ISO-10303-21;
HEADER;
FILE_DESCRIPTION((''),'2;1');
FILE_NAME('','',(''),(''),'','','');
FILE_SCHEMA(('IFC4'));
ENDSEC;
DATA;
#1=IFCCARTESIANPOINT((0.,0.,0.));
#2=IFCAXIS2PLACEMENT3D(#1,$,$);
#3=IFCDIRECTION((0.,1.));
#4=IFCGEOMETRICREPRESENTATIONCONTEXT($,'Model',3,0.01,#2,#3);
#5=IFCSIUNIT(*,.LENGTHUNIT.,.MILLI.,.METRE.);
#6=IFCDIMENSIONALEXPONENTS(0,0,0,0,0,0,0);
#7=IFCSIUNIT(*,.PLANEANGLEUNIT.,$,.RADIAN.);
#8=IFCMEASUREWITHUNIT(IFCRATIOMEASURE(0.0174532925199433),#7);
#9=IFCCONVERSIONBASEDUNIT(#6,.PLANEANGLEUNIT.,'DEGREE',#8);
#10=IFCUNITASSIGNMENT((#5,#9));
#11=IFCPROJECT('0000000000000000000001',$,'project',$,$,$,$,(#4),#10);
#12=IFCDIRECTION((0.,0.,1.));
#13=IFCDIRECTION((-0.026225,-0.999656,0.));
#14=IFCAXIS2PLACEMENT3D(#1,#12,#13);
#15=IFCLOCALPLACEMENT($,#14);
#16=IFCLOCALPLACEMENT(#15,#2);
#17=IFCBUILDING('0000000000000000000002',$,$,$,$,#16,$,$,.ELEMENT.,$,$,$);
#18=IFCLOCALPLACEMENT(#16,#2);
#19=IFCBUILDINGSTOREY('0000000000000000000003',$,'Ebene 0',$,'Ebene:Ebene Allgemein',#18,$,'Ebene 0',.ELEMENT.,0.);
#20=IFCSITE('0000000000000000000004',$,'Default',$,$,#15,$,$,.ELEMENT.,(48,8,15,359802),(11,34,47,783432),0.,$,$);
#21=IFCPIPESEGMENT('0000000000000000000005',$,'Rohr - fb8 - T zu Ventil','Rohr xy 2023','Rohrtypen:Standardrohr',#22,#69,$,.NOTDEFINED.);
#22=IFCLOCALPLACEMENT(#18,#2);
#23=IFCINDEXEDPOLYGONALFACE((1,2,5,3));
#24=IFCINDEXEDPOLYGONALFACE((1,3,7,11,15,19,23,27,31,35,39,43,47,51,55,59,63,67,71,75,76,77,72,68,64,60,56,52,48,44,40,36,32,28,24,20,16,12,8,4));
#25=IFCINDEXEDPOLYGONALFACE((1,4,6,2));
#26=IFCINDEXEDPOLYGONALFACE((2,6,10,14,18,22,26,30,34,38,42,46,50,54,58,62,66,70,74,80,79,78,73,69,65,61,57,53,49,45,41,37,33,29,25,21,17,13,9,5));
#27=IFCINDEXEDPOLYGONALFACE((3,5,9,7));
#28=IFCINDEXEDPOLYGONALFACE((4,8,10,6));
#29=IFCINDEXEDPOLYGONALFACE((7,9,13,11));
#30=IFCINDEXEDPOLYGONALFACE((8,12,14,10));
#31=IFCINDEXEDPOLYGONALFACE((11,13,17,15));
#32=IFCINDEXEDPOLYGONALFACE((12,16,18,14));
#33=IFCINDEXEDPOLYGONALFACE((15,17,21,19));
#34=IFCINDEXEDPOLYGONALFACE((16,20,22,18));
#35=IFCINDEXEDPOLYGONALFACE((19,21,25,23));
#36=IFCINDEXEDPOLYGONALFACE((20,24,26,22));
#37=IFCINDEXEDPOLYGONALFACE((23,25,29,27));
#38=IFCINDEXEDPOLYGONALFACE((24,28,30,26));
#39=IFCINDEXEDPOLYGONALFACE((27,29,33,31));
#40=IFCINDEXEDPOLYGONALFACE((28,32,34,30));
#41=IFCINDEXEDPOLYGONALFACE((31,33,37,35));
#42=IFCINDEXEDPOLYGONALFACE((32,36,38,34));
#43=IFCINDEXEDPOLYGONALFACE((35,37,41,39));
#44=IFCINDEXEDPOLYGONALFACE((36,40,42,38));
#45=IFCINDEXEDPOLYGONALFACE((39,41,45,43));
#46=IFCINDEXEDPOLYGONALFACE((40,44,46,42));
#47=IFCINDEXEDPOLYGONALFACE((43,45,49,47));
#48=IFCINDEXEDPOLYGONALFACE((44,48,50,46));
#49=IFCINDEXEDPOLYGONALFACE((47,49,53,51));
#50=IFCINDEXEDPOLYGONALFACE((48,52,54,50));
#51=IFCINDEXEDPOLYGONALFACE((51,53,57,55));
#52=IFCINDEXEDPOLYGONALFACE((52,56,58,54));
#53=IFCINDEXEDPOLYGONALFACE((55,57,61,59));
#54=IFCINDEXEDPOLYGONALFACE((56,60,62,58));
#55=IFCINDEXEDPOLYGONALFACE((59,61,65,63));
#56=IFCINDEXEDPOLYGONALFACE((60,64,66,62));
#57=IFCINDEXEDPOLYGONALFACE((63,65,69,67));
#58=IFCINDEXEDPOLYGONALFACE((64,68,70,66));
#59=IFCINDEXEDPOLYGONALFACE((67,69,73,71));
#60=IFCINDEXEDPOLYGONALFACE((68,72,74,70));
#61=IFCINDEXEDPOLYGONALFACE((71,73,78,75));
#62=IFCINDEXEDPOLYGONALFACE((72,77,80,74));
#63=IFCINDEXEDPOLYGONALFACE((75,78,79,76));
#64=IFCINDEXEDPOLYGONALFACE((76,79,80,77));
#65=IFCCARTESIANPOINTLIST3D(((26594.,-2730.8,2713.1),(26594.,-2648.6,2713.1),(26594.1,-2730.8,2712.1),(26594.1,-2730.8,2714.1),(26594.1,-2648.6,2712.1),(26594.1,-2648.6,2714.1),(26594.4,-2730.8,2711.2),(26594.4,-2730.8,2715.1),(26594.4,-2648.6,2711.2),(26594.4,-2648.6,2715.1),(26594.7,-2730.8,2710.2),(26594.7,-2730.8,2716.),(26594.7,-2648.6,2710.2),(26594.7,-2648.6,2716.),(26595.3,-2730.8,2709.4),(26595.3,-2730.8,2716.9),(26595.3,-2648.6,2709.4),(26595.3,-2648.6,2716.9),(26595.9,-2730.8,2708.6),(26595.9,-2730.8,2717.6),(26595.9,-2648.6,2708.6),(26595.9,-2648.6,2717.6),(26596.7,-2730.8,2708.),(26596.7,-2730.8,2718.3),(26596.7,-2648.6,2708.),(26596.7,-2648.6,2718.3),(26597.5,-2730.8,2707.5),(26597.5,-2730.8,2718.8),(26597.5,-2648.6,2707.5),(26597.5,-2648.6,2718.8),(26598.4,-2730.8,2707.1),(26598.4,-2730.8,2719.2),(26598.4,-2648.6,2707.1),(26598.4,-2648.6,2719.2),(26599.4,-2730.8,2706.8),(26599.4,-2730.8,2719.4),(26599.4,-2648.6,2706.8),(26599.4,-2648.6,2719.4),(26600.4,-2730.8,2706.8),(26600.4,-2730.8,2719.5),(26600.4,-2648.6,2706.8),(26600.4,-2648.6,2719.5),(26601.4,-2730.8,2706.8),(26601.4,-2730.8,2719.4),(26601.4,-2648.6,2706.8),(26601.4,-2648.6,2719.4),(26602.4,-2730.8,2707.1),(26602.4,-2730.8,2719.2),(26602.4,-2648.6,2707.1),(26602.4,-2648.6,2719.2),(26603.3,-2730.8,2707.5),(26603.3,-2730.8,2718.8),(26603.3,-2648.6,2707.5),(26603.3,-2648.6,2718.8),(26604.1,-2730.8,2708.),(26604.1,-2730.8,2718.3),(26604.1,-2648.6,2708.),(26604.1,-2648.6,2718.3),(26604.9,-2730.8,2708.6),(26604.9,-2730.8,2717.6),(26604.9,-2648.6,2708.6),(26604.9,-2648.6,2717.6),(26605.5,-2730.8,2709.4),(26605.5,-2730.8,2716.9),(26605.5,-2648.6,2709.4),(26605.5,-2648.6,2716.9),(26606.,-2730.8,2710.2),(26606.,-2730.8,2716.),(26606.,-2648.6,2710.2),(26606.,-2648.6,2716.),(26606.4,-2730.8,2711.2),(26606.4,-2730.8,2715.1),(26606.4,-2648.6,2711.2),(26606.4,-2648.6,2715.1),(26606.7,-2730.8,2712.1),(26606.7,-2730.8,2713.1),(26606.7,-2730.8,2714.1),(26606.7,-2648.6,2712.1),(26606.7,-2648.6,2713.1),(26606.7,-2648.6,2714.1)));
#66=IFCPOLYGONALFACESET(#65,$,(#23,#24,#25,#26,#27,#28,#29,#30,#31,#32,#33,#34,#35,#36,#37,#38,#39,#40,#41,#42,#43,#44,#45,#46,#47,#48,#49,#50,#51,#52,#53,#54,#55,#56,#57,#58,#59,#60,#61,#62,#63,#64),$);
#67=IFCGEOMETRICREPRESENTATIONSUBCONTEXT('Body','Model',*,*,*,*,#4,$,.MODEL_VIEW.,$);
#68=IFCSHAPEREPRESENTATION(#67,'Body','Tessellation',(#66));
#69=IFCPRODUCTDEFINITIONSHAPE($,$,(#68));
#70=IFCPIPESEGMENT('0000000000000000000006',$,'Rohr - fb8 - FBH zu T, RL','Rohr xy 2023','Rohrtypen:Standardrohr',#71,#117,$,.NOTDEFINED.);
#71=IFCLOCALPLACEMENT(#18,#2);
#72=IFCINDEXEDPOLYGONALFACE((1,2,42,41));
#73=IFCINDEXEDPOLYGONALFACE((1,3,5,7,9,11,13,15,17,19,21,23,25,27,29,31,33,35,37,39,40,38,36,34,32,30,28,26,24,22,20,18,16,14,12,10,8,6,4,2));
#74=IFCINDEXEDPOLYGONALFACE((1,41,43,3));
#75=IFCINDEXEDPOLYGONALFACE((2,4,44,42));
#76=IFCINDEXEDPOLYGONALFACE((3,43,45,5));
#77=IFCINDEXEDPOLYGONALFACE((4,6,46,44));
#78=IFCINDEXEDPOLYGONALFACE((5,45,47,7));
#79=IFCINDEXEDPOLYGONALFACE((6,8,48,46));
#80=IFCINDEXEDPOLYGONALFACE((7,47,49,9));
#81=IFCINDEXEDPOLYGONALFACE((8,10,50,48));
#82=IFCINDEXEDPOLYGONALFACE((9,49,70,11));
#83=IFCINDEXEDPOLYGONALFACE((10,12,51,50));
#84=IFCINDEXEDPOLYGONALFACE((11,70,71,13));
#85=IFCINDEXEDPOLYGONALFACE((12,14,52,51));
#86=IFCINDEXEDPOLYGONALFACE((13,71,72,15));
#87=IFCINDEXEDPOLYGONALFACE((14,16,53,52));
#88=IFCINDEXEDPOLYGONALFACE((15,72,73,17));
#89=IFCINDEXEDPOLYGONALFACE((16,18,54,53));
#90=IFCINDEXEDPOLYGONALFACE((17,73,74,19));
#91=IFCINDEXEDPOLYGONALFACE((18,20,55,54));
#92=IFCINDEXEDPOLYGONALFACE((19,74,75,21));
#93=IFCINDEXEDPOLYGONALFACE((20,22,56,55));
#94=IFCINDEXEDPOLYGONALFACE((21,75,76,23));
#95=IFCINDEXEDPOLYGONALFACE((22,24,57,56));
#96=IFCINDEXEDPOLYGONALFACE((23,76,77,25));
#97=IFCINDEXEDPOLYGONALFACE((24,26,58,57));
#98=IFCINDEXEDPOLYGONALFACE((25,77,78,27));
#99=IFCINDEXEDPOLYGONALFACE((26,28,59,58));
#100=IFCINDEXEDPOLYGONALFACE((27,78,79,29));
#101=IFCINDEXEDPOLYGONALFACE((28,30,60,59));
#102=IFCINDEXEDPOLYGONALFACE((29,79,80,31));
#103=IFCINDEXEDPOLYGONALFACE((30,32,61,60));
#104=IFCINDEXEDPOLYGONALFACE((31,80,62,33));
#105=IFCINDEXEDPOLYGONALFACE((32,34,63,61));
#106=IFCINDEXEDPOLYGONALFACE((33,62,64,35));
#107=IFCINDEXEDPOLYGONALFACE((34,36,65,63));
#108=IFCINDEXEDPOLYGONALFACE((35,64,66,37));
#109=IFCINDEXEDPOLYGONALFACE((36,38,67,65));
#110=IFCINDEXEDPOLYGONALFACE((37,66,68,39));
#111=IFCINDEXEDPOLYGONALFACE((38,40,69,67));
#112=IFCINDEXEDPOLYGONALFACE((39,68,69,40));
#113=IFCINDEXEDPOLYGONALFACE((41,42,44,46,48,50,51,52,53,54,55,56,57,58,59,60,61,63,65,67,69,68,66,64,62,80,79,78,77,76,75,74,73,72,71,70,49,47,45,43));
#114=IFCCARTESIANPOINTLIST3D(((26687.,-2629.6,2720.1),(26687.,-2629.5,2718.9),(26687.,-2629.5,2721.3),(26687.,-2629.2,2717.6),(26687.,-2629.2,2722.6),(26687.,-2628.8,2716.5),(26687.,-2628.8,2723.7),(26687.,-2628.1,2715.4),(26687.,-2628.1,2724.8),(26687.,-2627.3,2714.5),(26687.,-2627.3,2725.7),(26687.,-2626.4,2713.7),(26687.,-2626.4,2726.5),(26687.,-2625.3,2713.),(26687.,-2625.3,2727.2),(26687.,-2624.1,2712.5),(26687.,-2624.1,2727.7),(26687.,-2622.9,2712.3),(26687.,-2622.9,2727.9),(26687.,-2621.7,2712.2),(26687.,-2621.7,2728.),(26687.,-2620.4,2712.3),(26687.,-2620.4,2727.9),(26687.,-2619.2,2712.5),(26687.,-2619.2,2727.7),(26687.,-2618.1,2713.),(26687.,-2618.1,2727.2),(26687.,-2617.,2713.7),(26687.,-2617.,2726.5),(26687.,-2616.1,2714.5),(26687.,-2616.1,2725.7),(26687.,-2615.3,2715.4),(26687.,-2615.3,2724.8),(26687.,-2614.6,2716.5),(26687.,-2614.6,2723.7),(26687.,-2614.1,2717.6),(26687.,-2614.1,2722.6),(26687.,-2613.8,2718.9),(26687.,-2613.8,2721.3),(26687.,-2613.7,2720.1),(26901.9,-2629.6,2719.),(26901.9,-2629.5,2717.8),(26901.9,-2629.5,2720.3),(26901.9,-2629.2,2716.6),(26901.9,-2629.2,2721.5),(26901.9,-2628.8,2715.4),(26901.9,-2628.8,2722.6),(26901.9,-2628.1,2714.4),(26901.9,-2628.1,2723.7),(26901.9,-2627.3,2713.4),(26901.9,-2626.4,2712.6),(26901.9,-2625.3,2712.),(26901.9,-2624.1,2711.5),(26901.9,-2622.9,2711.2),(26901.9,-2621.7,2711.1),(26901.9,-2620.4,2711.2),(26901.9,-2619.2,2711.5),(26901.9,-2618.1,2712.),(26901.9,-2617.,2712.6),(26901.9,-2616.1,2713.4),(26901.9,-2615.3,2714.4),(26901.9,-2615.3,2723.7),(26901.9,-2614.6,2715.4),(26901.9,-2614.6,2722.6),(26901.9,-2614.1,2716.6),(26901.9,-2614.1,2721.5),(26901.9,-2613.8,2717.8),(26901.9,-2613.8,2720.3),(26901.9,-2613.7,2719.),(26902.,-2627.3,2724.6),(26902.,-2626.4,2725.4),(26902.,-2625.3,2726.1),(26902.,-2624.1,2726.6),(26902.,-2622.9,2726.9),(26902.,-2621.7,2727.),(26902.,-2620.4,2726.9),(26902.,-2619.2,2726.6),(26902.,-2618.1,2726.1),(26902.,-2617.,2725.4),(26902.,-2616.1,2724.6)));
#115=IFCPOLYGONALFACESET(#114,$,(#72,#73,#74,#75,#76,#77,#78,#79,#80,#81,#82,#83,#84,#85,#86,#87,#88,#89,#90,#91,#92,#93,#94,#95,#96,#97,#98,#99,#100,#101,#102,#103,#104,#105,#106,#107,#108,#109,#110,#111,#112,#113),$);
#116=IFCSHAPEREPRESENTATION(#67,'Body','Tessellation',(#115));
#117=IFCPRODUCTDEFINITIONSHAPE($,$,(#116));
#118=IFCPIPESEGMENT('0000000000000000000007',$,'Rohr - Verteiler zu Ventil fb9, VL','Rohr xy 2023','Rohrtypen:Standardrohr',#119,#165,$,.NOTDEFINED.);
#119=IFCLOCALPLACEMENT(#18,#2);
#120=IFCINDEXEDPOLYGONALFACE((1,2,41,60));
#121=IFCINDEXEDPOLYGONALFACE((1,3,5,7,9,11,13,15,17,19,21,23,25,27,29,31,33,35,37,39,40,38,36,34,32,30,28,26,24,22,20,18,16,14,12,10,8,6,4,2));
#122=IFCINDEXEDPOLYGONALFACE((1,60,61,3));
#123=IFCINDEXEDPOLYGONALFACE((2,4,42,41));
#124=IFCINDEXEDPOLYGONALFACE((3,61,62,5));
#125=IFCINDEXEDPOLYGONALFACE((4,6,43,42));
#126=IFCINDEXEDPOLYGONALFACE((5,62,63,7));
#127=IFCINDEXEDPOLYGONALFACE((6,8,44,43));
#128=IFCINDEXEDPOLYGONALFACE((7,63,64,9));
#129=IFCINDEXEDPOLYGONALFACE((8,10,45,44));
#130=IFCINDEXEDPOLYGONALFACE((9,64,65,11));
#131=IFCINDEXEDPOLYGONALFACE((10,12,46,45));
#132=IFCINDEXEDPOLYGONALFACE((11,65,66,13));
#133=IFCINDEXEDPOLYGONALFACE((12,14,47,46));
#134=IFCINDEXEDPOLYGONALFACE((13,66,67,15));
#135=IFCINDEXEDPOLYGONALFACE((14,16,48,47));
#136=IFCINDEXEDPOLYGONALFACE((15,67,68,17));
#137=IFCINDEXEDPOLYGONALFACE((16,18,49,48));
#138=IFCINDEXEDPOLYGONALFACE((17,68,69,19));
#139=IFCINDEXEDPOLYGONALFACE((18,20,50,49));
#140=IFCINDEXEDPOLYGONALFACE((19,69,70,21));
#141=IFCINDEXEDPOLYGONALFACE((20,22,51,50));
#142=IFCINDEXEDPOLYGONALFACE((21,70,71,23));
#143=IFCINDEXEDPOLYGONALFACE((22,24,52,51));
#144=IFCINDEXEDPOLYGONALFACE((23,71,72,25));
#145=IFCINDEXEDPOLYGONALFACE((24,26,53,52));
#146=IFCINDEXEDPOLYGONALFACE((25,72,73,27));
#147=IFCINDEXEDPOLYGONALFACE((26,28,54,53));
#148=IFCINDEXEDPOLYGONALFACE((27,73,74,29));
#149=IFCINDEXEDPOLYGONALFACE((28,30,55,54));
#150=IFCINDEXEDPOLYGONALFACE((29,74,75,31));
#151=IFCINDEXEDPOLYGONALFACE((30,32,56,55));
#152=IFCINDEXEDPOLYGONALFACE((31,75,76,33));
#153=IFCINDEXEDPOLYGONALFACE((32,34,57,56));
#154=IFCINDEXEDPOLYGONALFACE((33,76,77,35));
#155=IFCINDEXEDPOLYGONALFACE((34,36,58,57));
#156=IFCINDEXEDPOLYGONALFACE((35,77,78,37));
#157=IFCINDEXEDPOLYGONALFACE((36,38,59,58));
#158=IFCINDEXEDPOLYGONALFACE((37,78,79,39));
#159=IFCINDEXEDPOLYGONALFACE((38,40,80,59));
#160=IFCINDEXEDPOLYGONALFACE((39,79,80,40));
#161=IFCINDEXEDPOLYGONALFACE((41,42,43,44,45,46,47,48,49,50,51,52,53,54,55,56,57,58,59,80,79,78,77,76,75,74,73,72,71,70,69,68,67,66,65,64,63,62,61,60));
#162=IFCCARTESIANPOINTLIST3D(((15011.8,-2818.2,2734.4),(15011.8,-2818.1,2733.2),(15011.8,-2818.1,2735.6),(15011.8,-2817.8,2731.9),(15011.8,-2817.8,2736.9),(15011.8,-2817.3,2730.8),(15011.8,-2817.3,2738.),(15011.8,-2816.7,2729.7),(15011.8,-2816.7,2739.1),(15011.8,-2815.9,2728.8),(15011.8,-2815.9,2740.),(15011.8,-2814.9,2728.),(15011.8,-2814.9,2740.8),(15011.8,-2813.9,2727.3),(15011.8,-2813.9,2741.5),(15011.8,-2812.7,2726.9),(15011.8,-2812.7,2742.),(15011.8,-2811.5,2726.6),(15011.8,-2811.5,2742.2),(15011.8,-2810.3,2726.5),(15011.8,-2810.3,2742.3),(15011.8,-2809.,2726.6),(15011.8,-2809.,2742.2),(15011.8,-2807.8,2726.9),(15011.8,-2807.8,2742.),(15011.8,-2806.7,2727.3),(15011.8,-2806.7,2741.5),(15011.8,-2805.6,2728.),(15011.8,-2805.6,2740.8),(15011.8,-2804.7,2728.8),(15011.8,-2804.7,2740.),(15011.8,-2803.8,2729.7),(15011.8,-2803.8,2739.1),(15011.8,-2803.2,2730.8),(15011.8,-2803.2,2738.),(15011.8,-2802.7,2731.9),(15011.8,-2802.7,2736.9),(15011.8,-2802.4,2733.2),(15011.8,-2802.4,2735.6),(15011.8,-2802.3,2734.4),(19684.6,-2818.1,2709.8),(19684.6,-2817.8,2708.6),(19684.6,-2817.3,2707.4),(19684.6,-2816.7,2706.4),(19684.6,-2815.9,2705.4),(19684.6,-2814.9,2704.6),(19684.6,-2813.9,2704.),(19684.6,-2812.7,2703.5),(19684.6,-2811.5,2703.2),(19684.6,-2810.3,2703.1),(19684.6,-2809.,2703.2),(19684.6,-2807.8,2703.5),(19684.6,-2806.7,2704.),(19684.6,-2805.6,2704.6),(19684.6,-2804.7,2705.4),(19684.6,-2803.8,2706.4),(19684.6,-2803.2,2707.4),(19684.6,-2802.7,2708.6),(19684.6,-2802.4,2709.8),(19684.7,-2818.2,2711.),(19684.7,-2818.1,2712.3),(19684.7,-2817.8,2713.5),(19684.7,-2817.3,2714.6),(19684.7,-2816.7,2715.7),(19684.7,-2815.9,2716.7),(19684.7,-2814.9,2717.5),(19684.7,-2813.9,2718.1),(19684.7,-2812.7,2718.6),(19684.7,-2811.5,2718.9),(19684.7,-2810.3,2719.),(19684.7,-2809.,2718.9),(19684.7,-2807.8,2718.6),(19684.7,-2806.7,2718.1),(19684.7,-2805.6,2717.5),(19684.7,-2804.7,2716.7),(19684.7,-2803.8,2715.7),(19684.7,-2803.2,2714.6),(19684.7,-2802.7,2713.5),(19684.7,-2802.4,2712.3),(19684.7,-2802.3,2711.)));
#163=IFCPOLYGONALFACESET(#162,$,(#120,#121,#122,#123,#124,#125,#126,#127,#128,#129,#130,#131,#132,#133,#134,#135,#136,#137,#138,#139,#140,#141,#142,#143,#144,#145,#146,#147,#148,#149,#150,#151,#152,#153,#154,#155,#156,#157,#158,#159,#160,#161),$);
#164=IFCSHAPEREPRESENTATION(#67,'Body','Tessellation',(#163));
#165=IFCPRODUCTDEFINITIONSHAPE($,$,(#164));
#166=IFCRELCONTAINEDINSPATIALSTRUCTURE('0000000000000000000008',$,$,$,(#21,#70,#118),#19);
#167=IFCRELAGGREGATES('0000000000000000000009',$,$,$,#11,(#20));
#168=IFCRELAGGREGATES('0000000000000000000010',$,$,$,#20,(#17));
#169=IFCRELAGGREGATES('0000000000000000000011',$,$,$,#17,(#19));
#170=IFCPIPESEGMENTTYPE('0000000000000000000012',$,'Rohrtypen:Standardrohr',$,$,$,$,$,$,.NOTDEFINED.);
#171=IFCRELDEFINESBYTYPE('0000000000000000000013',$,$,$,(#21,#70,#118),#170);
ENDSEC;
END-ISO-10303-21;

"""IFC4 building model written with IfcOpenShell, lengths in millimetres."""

from ifc_helpers import new_model, entity, si_unit, converted_unit, direction, frame, origin, place, context, subcontext, project, spatial, indexed_curve, outline, extrude, type_object, element, save


model = new_model("IFC4")

# Units and contexts
model_context = context("Model", 3, precision=0.01, world=origin(), true_north=direction((0.0, 1.0)))
body_context = subcontext(model_context, "Body", "Model", "MODEL_VIEW")
ifc_project = project(units=[si_unit("LENGTHUNIT", "METRE", prefix="MILLI"), converted_unit("PLANEANGLEUNIT", "DEGREE", entity("IfcRatioMeasure", 0.0174532925199433), si_unit("PLANEANGLEUNIT", "RADIAN"), dimensions=[0, 0, 0, 0, 0, 0, 0])], contexts=[model_context])

# Site, building, storey
site_placement = place(None, frame((0.0, 0.0, 0.0), z_axis=(0.0, 0.0, 1.0), x_axis=(-0.026225, -0.999656, 0.0)))
site = spatial("IfcSite", under=ifc_project, at=site_placement, Name="Default", CompositionType="ELEMENT", RefLatitude=(48, 8, 15, 359802), RefLongitude=(11, 34, 47, 783432), RefElevation=0.0)
building_placement = place(site_placement, origin())
building = spatial("IfcBuilding", under=site, at=building_placement, CompositionType="ELEMENT")
storey_placement = place(building_placement, origin())
storey = spatial("IfcBuildingStorey", under=building, at=storey_placement, Name="Ebene 0", ObjectType="Ebene:Ebene Allgemein", LongName="Ebene 0", CompositionType="ELEMENT", Elevation=0.0)

# Pipe segments
pipe_segment_type = type_object("IfcPipeSegmentType", Name="Rohrtypen:Standardrohr", PredefinedType="NOTDEFINED")
pipe_segment_1_placement = place(storey_placement, origin())
element("IfcPipeSegment", 1, at=pipe_segment_1_placement, inside=storey, type_object=pipe_segment_type, Name="Rohr - fb8 - T zu Ventil", Description="Rohr xy 2023", ObjectType="Rohrtypen:Standardrohr", PredefinedType="NOTDEFINED", context=body_context, shape_type="SweptSolid", body=[
    extrude(outline(indexed_curve([(6.3, 0.0), (6.3, 1.0), (6.0, 2.0), (5.7, 2.9), (5.1, 3.7), (4.5, 4.5), (3.7, 5.1), (2.9, 5.7), (2.0, 6.0), (1.0, 6.3), (0.0, 6.4), (-1.0, 6.3), (-2.0, 6.0), (-2.9, 5.7), (-3.7, 5.1), (-4.5, 4.5), (-5.1, 3.7), (-5.7, 2.9), (-6.0, 2.0), (-6.3, 1.0), (-6.4, 0.0), (-6.3, -1.0), (-6.0, -2.0), (-5.7, -2.9), (-5.1, -3.7), (-4.5, -4.5), (-3.7, -5.1), (-2.9, -5.7), (-2.0, -6.0), (-1.0, -6.3), (0.0, -6.4), (1.0, -6.3), (2.0, -6.0), (2.9, -5.7), (3.7, -5.1), (4.5, -4.5), (5.1, -3.7), (5.7, -2.9), (6.0, -2.0), (6.3, -1.0), (6.3, 0.0)], self_intersect=False)), frame((26600.4, -2730.8, 2713.1), z_axis=(0.0, 1.0, 0.0), x_axis=(-1.0, 0.0, 0.0)), (0.0, 0.0, 1.0), 82.2),
])
pipe_segment_2_placement = place(storey_placement, origin())
element("IfcPipeSegment", 2, at=pipe_segment_2_placement, inside=storey, type_object=pipe_segment_type, Name="Rohr - fb8 - FBH zu T, RL", Description="Rohr xy 2023", ObjectType="Rohrtypen:Standardrohr", PredefinedType="NOTDEFINED", context=body_context, shape_type="SweptSolid", body=[
    extrude(outline(indexed_curve([(7.9, 0.0), (7.8, 1.2), (7.6, 2.5), (7.1, 3.6), (6.4, 4.7), (5.6, 5.6), (4.7, 6.4), (3.6, 7.1), (2.5, 7.6), (1.2, 7.8), (0.0, 7.9), (-1.2, 7.8), (-2.5, 7.6), (-3.6, 7.1), (-4.7, 6.4), (-5.6, 5.6), (-6.4, 4.7), (-7.1, 3.6), (-7.6, 2.5), (-7.8, 1.2), (-7.9, 0.0), (-7.8, -1.2), (-7.6, -2.5), (-7.1, -3.6), (-6.4, -4.7), (-5.6, -5.6), (-4.7, -6.4), (-3.6, -7.1), (-2.5, -7.6), (-1.2, -7.8), (0.0, -7.9), (1.2, -7.8), (2.5, -7.6), (3.6, -7.1), (4.7, -6.4), (5.6, -5.6), (6.4, -4.7), (7.1, -3.6), (7.6, -2.5), (7.8, -1.2), (7.9, 0.0)], self_intersect=False)), frame((26901.9, -2621.7, 2719.0), z_axis=(-0.999988, 0.0, 0.005), x_axis=(0.0, 1.0, 0.0)), (0.0, 0.0, 1.0), 214.9),
])
pipe_segment_3_placement = place(storey_placement, origin())
element("IfcPipeSegment", 3, at=pipe_segment_3_placement, inside=storey, type_object=pipe_segment_type, Name="Rohr - Verteiler zu Ventil fb9, VL", Description="Rohr xy 2023", ObjectType="Rohrtypen:Standardrohr", PredefinedType="NOTDEFINED", context=body_context, shape_type="SweptSolid", body=[
    extrude(outline(indexed_curve([(7.9, 0.0), (7.8, 1.2), (7.6, 2.5), (7.1, 3.6), (6.4, 4.7), (5.6, 5.6), (4.7, 6.4), (3.6, 7.1), (2.5, 7.6), (1.2, 7.8), (0.0, 7.9), (-1.2, 7.8), (-2.5, 7.6), (-3.6, 7.1), (-4.7, 6.4), (-5.6, 5.6), (-6.4, 4.7), (-7.1, 3.6), (-7.6, 2.5), (-7.8, 1.2), (-7.9, 0.0), (-7.8, -1.2), (-7.6, -2.5), (-7.1, -3.6), (-6.4, -4.7), (-5.6, -5.6), (-4.7, -6.4), (-3.6, -7.1), (-2.5, -7.6), (-1.2, -7.8), (0.0, -7.9), (1.2, -7.8), (2.5, -7.6), (3.6, -7.1), (4.7, -6.4), (5.6, -5.6), (6.4, -4.7), (7.1, -3.6), (7.6, -2.5), (7.8, -1.2), (7.9, 0.0)], self_intersect=False)), frame((19684.7, -2810.3, 2711.0), z_axis=(-0.999988, 0.0, 0.005), x_axis=(0.0, 1.0, 0.0)), (0.0, 0.0, 1.0), 4672.9),
])

save(model, "model.ifc")
